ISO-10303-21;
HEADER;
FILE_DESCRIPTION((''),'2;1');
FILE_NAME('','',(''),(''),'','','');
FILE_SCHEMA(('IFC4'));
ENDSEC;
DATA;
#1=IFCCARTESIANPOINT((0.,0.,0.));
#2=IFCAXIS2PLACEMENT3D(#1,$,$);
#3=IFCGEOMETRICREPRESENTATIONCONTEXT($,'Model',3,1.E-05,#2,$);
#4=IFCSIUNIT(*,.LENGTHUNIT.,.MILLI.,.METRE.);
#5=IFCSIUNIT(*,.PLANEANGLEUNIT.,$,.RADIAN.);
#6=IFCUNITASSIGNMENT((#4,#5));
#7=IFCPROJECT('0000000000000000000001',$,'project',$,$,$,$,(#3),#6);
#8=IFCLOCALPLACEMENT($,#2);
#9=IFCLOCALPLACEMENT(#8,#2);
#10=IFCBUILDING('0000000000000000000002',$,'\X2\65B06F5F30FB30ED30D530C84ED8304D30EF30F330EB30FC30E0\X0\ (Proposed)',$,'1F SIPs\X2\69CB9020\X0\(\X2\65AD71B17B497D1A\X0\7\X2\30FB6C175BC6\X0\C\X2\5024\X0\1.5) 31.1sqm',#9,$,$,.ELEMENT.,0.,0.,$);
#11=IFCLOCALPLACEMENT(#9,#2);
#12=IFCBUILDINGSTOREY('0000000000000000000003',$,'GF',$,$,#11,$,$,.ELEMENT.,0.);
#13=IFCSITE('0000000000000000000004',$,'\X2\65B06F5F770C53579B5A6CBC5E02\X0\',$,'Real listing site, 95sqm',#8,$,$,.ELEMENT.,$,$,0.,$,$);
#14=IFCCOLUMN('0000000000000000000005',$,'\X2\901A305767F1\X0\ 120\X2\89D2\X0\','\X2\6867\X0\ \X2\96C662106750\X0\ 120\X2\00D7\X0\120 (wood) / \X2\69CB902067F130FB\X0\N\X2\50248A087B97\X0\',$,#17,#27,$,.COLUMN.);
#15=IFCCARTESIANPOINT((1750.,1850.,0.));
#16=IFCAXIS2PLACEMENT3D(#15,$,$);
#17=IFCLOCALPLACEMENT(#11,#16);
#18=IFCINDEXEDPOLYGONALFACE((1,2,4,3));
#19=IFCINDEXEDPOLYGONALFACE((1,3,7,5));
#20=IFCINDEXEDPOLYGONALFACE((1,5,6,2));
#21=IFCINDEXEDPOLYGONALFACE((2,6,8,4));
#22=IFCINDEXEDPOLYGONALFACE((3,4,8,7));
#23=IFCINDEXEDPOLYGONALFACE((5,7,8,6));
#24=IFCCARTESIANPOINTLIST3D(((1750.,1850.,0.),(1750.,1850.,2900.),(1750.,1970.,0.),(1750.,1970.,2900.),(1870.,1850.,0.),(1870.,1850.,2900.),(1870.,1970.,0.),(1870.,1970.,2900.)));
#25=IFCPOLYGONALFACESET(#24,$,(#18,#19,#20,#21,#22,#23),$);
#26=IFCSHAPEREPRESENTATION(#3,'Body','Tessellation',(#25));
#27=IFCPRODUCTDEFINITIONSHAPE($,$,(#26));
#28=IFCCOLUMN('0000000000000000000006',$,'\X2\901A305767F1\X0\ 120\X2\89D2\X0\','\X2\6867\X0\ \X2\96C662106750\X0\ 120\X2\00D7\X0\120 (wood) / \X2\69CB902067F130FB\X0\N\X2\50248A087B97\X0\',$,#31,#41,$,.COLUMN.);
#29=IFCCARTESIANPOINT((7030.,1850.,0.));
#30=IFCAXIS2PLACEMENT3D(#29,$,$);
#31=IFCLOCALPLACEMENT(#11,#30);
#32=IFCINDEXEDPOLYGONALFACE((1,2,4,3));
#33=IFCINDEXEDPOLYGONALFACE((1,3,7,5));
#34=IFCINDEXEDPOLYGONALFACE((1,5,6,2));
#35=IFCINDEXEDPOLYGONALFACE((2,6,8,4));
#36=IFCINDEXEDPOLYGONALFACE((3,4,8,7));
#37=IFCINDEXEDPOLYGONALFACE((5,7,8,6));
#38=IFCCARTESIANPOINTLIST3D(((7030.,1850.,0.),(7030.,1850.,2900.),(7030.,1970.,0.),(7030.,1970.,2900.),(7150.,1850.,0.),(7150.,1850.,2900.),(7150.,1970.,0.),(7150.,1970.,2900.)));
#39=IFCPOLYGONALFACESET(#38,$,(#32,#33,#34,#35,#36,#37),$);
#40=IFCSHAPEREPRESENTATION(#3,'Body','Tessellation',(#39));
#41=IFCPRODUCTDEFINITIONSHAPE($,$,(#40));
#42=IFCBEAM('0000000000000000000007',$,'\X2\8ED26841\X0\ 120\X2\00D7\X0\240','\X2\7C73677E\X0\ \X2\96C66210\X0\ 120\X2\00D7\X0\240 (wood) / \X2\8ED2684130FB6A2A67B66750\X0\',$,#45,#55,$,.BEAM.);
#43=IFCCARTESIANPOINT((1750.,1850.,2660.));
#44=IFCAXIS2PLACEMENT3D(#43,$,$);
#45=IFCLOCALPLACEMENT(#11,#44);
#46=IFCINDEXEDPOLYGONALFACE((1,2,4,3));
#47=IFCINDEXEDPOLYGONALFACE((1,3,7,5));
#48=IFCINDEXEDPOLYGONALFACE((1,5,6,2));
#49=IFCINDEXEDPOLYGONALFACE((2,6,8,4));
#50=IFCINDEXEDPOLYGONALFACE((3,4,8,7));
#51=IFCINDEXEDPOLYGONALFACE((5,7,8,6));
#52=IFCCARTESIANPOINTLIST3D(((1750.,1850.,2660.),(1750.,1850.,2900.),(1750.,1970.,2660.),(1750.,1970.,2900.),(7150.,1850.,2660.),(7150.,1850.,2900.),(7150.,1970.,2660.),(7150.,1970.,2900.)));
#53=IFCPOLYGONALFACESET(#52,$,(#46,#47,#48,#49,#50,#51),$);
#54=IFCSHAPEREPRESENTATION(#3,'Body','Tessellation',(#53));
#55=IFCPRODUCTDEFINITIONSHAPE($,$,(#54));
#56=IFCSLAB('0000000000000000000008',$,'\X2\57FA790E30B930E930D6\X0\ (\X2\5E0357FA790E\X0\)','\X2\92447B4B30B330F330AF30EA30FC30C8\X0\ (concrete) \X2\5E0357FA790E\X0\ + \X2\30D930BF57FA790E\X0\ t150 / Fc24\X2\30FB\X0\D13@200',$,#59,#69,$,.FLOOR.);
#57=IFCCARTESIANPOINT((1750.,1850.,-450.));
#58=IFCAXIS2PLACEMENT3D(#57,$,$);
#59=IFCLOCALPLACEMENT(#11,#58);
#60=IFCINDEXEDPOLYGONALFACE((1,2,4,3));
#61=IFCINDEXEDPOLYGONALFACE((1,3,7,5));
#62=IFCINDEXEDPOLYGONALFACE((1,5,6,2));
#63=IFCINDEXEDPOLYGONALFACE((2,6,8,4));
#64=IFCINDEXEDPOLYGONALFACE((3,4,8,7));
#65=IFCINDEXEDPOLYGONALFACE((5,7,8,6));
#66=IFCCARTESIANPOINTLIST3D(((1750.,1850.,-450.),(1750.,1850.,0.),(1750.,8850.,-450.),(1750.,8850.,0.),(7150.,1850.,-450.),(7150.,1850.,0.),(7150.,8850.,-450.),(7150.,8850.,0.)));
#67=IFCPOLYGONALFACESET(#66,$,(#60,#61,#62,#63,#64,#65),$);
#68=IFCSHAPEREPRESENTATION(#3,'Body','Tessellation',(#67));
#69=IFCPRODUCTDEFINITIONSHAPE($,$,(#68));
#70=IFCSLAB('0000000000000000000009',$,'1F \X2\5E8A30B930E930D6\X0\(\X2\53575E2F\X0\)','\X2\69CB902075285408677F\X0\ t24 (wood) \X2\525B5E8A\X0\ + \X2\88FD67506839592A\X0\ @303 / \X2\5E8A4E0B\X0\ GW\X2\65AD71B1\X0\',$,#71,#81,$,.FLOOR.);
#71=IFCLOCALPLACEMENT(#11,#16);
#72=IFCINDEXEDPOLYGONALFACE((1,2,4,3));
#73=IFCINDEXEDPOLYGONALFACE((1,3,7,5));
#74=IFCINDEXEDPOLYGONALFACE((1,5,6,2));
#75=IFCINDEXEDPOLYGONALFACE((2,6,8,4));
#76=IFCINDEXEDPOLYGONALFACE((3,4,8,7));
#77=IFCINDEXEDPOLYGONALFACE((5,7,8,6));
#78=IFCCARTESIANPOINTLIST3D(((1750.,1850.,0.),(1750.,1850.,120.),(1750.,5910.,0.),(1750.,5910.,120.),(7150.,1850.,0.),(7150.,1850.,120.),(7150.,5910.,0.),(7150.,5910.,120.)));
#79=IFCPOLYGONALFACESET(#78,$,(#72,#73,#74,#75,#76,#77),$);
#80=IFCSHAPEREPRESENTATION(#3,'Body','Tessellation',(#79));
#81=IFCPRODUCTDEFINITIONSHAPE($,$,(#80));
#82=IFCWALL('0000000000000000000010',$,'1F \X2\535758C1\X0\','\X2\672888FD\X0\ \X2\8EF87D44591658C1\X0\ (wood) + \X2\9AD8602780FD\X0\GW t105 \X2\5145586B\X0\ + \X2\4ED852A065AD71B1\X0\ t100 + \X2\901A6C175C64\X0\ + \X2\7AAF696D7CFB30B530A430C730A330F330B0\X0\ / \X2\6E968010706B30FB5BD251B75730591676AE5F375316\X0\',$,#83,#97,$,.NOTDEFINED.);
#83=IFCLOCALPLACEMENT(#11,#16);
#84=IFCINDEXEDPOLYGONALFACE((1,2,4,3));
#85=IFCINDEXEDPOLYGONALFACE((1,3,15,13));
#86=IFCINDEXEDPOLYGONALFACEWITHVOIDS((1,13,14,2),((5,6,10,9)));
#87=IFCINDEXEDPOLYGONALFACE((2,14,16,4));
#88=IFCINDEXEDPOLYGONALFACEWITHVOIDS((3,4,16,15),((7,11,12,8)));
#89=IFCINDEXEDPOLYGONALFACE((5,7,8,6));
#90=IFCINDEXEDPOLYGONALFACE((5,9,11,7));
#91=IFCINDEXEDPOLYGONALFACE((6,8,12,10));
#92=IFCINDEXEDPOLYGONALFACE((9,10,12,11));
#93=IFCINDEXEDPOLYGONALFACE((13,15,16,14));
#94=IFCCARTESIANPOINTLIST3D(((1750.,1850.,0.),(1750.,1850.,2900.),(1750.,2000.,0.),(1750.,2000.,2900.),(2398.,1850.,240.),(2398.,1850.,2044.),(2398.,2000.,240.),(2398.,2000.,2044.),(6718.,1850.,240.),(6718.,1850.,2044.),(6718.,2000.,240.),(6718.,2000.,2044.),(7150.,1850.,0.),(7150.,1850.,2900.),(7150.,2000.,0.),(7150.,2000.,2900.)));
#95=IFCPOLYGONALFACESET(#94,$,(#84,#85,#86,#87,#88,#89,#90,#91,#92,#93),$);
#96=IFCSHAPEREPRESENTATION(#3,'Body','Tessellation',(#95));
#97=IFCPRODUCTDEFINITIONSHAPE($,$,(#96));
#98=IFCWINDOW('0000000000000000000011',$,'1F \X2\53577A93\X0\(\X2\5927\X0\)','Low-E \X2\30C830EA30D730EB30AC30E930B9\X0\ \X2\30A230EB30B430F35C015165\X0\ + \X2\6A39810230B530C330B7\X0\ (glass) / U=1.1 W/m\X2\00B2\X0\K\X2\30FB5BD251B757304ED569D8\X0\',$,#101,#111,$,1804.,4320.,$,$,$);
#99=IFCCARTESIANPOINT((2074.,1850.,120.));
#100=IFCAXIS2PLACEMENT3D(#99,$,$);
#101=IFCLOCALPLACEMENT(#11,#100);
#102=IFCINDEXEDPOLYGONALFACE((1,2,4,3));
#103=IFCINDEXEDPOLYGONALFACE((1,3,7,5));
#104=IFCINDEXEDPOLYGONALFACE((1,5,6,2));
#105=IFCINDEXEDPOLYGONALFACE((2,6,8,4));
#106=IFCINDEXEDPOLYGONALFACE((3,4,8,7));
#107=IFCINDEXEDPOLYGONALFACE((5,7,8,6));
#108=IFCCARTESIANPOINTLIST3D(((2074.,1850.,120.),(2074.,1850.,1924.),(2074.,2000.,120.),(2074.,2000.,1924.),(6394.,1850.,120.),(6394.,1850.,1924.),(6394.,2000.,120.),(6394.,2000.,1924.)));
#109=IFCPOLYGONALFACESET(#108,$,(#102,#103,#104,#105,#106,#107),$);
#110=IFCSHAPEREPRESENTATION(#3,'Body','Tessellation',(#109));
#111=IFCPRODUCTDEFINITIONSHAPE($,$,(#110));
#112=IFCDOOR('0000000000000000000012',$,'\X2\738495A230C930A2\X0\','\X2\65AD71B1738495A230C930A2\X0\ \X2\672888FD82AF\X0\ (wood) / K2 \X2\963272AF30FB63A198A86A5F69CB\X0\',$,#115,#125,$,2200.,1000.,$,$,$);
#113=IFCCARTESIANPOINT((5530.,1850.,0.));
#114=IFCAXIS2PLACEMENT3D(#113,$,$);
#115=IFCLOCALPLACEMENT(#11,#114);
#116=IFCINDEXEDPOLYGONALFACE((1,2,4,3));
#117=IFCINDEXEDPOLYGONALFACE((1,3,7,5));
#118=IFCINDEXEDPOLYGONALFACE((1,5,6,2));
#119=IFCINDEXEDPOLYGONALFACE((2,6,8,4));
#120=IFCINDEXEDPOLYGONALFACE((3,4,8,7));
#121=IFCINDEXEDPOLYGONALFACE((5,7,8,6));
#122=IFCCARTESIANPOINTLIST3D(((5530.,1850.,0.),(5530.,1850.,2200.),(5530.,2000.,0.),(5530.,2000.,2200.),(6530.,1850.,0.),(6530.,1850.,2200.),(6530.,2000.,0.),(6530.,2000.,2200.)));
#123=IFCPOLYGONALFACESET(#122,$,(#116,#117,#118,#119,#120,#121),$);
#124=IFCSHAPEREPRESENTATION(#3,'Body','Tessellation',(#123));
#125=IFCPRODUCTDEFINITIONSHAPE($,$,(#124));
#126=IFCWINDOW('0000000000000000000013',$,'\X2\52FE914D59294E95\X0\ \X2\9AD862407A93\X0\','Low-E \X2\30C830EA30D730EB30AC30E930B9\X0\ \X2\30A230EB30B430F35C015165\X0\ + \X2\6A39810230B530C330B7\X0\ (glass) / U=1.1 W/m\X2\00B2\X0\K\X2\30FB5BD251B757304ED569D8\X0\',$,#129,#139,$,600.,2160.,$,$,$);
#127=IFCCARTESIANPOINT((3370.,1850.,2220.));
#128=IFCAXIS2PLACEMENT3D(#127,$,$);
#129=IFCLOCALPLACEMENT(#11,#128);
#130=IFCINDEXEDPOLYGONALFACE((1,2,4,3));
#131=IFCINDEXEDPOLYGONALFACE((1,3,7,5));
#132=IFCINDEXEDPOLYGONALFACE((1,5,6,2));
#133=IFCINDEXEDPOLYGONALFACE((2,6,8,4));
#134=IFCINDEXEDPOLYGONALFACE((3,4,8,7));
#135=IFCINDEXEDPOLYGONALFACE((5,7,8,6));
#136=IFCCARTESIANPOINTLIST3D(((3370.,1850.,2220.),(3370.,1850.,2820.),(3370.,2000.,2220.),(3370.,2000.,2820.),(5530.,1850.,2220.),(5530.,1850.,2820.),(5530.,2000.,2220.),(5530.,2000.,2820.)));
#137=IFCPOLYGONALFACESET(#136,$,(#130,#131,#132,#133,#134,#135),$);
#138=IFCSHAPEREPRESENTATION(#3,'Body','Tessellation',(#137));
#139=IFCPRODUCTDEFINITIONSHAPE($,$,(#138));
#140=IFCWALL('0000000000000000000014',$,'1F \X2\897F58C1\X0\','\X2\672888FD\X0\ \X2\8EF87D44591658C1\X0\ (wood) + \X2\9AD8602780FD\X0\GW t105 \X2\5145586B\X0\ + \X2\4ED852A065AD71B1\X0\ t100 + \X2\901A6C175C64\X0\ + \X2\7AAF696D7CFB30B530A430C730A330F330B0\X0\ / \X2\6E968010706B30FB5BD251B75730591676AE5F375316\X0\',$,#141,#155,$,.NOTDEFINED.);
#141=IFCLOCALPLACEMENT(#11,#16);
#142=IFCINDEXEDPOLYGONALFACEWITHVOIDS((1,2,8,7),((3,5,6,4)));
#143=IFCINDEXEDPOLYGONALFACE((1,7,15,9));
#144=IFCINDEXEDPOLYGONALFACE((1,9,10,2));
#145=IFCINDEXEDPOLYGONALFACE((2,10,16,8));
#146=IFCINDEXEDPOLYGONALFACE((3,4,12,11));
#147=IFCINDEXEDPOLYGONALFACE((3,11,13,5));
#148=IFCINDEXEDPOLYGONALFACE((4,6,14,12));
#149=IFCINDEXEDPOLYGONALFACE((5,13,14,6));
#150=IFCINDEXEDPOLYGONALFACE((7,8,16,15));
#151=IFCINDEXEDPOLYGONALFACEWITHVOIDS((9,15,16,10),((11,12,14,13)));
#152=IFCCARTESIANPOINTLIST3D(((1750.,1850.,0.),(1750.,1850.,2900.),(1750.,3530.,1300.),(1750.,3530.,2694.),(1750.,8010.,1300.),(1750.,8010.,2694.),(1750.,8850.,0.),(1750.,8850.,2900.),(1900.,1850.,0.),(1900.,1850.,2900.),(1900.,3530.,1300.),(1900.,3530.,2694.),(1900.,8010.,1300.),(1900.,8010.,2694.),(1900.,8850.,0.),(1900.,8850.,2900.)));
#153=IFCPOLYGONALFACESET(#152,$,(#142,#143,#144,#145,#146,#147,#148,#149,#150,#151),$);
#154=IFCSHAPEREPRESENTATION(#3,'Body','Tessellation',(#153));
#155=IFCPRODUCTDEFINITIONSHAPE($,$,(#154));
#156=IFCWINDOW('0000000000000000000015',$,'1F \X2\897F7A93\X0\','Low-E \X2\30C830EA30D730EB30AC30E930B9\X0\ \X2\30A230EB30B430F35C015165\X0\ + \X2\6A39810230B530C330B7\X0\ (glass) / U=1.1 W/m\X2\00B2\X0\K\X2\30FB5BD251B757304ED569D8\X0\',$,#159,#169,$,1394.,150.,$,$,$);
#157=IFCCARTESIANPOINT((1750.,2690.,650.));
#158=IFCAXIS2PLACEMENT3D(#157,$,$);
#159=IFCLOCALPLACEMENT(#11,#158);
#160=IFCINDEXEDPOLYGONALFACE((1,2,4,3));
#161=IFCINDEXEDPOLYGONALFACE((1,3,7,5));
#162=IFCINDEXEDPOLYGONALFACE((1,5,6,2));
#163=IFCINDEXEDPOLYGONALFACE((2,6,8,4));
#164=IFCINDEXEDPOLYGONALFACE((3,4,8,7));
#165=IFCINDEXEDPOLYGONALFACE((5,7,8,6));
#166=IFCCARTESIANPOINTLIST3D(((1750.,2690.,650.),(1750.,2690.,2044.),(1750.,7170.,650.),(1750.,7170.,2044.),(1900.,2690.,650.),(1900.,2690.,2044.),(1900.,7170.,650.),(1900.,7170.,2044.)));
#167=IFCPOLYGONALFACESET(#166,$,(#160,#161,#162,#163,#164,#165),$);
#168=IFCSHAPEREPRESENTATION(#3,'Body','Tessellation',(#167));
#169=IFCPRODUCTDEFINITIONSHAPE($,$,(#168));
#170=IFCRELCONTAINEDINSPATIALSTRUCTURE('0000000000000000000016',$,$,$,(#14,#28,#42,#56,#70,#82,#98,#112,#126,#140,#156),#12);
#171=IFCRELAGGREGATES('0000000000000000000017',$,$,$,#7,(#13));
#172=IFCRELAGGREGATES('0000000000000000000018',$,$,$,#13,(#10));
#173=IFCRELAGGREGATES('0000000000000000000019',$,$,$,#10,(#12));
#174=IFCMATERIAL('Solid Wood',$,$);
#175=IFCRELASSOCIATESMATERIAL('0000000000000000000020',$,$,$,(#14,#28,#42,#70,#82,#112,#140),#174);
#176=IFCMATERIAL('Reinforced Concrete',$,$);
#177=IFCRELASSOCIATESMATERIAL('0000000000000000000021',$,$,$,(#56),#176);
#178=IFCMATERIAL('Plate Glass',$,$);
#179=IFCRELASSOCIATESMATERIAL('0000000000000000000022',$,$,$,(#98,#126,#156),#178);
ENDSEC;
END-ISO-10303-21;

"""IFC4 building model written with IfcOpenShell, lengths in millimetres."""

from ifc_helpers import new_model, si_unit, frame, frame_2d, origin, place, context, project, spatial, rectangle, extrude, material, element, fill, save


model = new_model("IFC4")

# Units and contexts
model_context = context("Model", 3, precision=1e-05, world=origin())
ifc_project = project(units=[si_unit("LENGTHUNIT", "METRE", prefix="MILLI"), si_unit("PLANEANGLEUNIT", "RADIAN")], contexts=[model_context])

# Site, building, storey
site_placement = place(None, origin())
site = spatial("IfcSite", under=ifc_project, at=site_placement, Name="新潟県南魚沼市", ObjectType="Real listing site, 95sqm", CompositionType="ELEMENT", RefElevation=0.0)
building_placement = place(site_placement, origin())
building = spatial("IfcBuilding", under=site, at=building_placement, Name="新潟・ロフト付きワンルーム (Proposed)", ObjectType="1F SIPs構造(断熱等級7・気密C値1.5) 31.1sqm", CompositionType="ELEMENT", ElevationOfRefHeight=0.0, ElevationOfTerrain=0.0)
storey_placement = place(building_placement, origin())
storey = spatial("IfcBuildingStorey", under=building, at=storey_placement, Name="GF", CompositionType="ELEMENT", Elevation=0.0)

# Columns
ifc_material_1 = material(Name="Solid Wood")
column_1_placement = place(storey_placement, frame((1750.0, 1850.0, 0.0)))
element("IfcColumn", 1, at=column_1_placement, inside=storey, material=ifc_material_1, Name="通し柱 120角", Description="桧 集成材 120×120 (wood) / 構造柱・N値計算", PredefinedType="COLUMN", context=model_context, shape_type="SweptSolid", body=[
    extrude(rectangle(XDim=120.0, YDim=120.0, at=frame_2d((60.0, 60.0))), frame((1750.0, 1850.0, 0.0)), (0.0, 0.0, 1.0), 2900.0),
])
column_2_placement = place(storey_placement, frame((7030.0, 1850.0, 0.0)))
element("IfcColumn", 2, at=column_2_placement, inside=storey, material=ifc_material_1, Name="通し柱 120角", Description="桧 集成材 120×120 (wood) / 構造柱・N値計算", PredefinedType="COLUMN", context=model_context, shape_type="SweptSolid", body=[
    extrude(rectangle(XDim=120.0, YDim=120.0, at=frame_2d((60.0, 60.0))), frame((7030.0, 1850.0, 0.0)), (0.0, 0.0, 1.0), 2900.0),
])

# Beam
beam_1_placement = place(storey_placement, frame((1750.0, 1850.0, 2660.0)))
element("IfcBeam", 3, at=beam_1_placement, inside=storey, material=ifc_material_1, Name="軒桁 120×240", Description="米松 集成 120×240 (wood) / 軒桁・横架材", PredefinedType="BEAM", context=model_context, shape_type="SweptSolid", body=[
    extrude(rectangle(XDim=5400.0, YDim=120.0, at=frame_2d((2700.0, 60.0))), frame((1750.0, 1850.0, 2660.0)), (0.0, 0.0, 1.0), 240.0),
])

# Slabs
ifc_material_2 = material(Name="Reinforced Concrete")
slab_1_placement = place(storey_placement, frame((1750.0, 1850.0, -450.0)))
element("IfcSlab", 4, at=slab_1_placement, inside=storey, material=ifc_material_2, Name="基礎スラブ (布基礎)", Description="鉄筋コンクリート (concrete) 布基礎 + ベタ基礎 t150 / Fc24・D13@200", PredefinedType="FLOOR", context=model_context, shape_type="SweptSolid", body=[
    extrude(rectangle(XDim=5400.0, YDim=7000.0, at=frame_2d((2700.0, 3500.0))), frame((1750.0, 1850.0, -450.0)), (0.0, 0.0, 1.0), 450.0),
])
slab_2_placement = place(storey_placement, frame((1750.0, 1850.0, 0.0)))
element("IfcSlab", 5, at=slab_2_placement, inside=storey, material=ifc_material_1, Name="1F 床スラブ(南帯)", Description="構造用合板 t24 (wood) 剛床 + 製材根太 @303 / 床下 GW断熱", PredefinedType="FLOOR", context=model_context, shape_type="SweptSolid", body=[
    extrude(rectangle(XDim=5400.0, YDim=4060.0, at=frame_2d((2700.0, 2030.0))), frame((1750.0, 1850.0, 0.0)), (0.0, 0.0, 1.0), 120.0),
])

# Wall, openings, windows, door
wall_1_placement = place(storey_placement, frame((1750.0, 1850.0, 0.0)))
wall_1 = element("IfcWall", 6, at=wall_1_placement, inside=storey, material=ifc_material_1, Name="1F 南壁", Description="木製 軸組外壁 (wood) + 高性能GW t105 充填 + 付加断熱 t100 + 通気層 + 窯業系サイディング / 準耐火・寒冷地外皮強化", PredefinedType="NOTDEFINED", context=model_context, shape_type="SweptSolid", body=[
    extrude(rectangle(XDim=5400.0, YDim=150.0, at=frame_2d((2700.0, 75.0))), frame((1750.0, 1850.0, 0.0)), (0.0, 0.0, 1.0), 2900.0),
])
opening_1_placement = place(storey_placement, frame((2074.0, 1850.0, 120.0)))
opening_1 = element("IfcOpeningElement", 7, at=opening_1_placement, cuts=wall_1, PredefinedType="NOTDEFINED", context=model_context, shape_type="SweptSolid", body=[
    extrude(rectangle(XDim=4320.0, YDim=150.0, at=frame_2d((2160.0, 75.0))), frame((2074.0, 1850.0, 120.0)), (0.0, 0.0, 1.0), 1804.0),
])
opening_2_placement = place(storey_placement, frame((5530.0, 1850.0, 0.0)))
opening_2 = element("IfcOpeningElement", 8, at=opening_2_placement, cuts=wall_1, PredefinedType="NOTDEFINED", context=model_context, shape_type="SweptSolid", body=[
    extrude(rectangle(XDim=1000.0, YDim=150.0, at=frame_2d((500.0, 75.0))), frame((5530.0, 1850.0, 0.0)), (0.0, 0.0, 1.0), 2200.0),
])
opening_3_placement = place(storey_placement, frame((3370.0, 1850.0, 2220.0)))
opening_3 = element("IfcOpeningElement", 9, at=opening_3_placement, cuts=wall_1, PredefinedType="NOTDEFINED", context=model_context, shape_type="SweptSolid", body=[
    extrude(rectangle(XDim=2160.0, YDim=150.0, at=frame_2d((1080.0, 75.0))), frame((3370.0, 1850.0, 2220.0)), (0.0, 0.0, 1.0), 600.0),
])
ifc_material_3 = material(Name="Plate Glass")
window_1_placement = place(storey_placement, frame((2074.0, 1850.0, 120.0)))
window_1 = element("IfcWindow", 10, at=window_1_placement, inside=storey, material=ifc_material_3, Name="1F 南窓(大)", Description="Low-E トリプルガラス アルゴン封入 + 樹脂サッシ (glass) / U=1.1 W/m²K・寒冷地仕様", OverallHeight=1804.0, OverallWidth=4320.0, context=model_context, shape_type="SweptSolid", body=[
    extrude(rectangle(XDim=4320.0, YDim=150.0, at=frame_2d((2160.0, 75.0))), frame((2074.0, 1850.0, 120.0)), (0.0, 0.0, 1.0), 1804.0),
])
fill(opening_1, window_1)
door_1_placement = place(storey_placement, frame((5530.0, 1850.0, 0.0)))
door_1 = element("IfcDoor", 11, at=door_1_placement, inside=storey, material=ifc_material_1, Name="玄関ドア", Description="断熱玄関ドア 木製芯 (wood) / K2 防犯・採風機構", OverallHeight=2200.0, OverallWidth=1000.0, context=model_context, shape_type="SweptSolid", body=[
    extrude(rectangle(XDim=1000.0, YDim=150.0, at=frame_2d((500.0, 75.0))), frame((5530.0, 1850.0, 0.0)), (0.0, 0.0, 1.0), 2200.0),
])
fill(opening_2, door_1)
window_2_placement = place(storey_placement, frame((3370.0, 1850.0, 2220.0)))
window_2 = element("IfcWindow", 12, at=window_2_placement, inside=storey, material=ifc_material_3, Name="勾配天井 高所窓", Description="Low-E トリプルガラス アルゴン封入 + 樹脂サッシ (glass) / U=1.1 W/m²K・寒冷地仕様", OverallHeight=600.0, OverallWidth=2160.0, context=model_context, shape_type="SweptSolid", body=[
    extrude(rectangle(XDim=2160.0, YDim=150.0, at=frame_2d((1080.0, 75.0))), frame((3370.0, 1850.0, 2220.0)), (0.0, 0.0, 1.0), 600.0),
])
fill(opening_3, window_2)

# Wall, opening, window
wall_2_placement = place(storey_placement, frame((1750.0, 1850.0, 0.0)))
wall_2 = element("IfcWall", 13, at=wall_2_placement, inside=storey, material=ifc_material_1, Name="1F 西壁", Description="木製 軸組外壁 (wood) + 高性能GW t105 充填 + 付加断熱 t100 + 通気層 + 窯業系サイディング / 準耐火・寒冷地外皮強化", PredefinedType="NOTDEFINED", context=model_context, shape_type="SweptSolid", body=[
    extrude(rectangle(XDim=150.0, YDim=7000.0, at=frame_2d((75.0, 3500.0))), frame((1750.0, 1850.0, 0.0)), (0.0, 0.0, 1.0), 2900.0),
])
opening_4_placement = place(storey_placement, frame((1750.0, 2690.0, 650.0)))
opening_4 = element("IfcOpeningElement", 14, at=opening_4_placement, cuts=wall_2, PredefinedType="NOTDEFINED", context=model_context, shape_type="SweptSolid", body=[
    extrude(rectangle(XDim=150.0, YDim=4480.0, at=frame_2d((75.0, 2240.0))), frame((1750.0, 2690.0, 650.0)), (0.0, 0.0, 1.0), 1394.0),
])
window_3_placement = place(storey_placement, frame((1750.0, 2690.0, 650.0)))
window_3 = element("IfcWindow", 15, at=window_3_placement, inside=storey, material=ifc_material_3, Name="1F 西窓", Description="Low-E トリプルガラス アルゴン封入 + 樹脂サッシ (glass) / U=1.1 W/m²K・寒冷地仕様", OverallHeight=1394.0, OverallWidth=150.0, context=model_context, shape_type="SweptSolid", body=[
    extrude(rectangle(XDim=150.0, YDim=4480.0, at=frame_2d((75.0, 2240.0))), frame((1750.0, 2690.0, 650.0)), (0.0, 0.0, 1.0), 1394.0),
])
fill(opening_4, window_3)

save(model, "model.ifc")
